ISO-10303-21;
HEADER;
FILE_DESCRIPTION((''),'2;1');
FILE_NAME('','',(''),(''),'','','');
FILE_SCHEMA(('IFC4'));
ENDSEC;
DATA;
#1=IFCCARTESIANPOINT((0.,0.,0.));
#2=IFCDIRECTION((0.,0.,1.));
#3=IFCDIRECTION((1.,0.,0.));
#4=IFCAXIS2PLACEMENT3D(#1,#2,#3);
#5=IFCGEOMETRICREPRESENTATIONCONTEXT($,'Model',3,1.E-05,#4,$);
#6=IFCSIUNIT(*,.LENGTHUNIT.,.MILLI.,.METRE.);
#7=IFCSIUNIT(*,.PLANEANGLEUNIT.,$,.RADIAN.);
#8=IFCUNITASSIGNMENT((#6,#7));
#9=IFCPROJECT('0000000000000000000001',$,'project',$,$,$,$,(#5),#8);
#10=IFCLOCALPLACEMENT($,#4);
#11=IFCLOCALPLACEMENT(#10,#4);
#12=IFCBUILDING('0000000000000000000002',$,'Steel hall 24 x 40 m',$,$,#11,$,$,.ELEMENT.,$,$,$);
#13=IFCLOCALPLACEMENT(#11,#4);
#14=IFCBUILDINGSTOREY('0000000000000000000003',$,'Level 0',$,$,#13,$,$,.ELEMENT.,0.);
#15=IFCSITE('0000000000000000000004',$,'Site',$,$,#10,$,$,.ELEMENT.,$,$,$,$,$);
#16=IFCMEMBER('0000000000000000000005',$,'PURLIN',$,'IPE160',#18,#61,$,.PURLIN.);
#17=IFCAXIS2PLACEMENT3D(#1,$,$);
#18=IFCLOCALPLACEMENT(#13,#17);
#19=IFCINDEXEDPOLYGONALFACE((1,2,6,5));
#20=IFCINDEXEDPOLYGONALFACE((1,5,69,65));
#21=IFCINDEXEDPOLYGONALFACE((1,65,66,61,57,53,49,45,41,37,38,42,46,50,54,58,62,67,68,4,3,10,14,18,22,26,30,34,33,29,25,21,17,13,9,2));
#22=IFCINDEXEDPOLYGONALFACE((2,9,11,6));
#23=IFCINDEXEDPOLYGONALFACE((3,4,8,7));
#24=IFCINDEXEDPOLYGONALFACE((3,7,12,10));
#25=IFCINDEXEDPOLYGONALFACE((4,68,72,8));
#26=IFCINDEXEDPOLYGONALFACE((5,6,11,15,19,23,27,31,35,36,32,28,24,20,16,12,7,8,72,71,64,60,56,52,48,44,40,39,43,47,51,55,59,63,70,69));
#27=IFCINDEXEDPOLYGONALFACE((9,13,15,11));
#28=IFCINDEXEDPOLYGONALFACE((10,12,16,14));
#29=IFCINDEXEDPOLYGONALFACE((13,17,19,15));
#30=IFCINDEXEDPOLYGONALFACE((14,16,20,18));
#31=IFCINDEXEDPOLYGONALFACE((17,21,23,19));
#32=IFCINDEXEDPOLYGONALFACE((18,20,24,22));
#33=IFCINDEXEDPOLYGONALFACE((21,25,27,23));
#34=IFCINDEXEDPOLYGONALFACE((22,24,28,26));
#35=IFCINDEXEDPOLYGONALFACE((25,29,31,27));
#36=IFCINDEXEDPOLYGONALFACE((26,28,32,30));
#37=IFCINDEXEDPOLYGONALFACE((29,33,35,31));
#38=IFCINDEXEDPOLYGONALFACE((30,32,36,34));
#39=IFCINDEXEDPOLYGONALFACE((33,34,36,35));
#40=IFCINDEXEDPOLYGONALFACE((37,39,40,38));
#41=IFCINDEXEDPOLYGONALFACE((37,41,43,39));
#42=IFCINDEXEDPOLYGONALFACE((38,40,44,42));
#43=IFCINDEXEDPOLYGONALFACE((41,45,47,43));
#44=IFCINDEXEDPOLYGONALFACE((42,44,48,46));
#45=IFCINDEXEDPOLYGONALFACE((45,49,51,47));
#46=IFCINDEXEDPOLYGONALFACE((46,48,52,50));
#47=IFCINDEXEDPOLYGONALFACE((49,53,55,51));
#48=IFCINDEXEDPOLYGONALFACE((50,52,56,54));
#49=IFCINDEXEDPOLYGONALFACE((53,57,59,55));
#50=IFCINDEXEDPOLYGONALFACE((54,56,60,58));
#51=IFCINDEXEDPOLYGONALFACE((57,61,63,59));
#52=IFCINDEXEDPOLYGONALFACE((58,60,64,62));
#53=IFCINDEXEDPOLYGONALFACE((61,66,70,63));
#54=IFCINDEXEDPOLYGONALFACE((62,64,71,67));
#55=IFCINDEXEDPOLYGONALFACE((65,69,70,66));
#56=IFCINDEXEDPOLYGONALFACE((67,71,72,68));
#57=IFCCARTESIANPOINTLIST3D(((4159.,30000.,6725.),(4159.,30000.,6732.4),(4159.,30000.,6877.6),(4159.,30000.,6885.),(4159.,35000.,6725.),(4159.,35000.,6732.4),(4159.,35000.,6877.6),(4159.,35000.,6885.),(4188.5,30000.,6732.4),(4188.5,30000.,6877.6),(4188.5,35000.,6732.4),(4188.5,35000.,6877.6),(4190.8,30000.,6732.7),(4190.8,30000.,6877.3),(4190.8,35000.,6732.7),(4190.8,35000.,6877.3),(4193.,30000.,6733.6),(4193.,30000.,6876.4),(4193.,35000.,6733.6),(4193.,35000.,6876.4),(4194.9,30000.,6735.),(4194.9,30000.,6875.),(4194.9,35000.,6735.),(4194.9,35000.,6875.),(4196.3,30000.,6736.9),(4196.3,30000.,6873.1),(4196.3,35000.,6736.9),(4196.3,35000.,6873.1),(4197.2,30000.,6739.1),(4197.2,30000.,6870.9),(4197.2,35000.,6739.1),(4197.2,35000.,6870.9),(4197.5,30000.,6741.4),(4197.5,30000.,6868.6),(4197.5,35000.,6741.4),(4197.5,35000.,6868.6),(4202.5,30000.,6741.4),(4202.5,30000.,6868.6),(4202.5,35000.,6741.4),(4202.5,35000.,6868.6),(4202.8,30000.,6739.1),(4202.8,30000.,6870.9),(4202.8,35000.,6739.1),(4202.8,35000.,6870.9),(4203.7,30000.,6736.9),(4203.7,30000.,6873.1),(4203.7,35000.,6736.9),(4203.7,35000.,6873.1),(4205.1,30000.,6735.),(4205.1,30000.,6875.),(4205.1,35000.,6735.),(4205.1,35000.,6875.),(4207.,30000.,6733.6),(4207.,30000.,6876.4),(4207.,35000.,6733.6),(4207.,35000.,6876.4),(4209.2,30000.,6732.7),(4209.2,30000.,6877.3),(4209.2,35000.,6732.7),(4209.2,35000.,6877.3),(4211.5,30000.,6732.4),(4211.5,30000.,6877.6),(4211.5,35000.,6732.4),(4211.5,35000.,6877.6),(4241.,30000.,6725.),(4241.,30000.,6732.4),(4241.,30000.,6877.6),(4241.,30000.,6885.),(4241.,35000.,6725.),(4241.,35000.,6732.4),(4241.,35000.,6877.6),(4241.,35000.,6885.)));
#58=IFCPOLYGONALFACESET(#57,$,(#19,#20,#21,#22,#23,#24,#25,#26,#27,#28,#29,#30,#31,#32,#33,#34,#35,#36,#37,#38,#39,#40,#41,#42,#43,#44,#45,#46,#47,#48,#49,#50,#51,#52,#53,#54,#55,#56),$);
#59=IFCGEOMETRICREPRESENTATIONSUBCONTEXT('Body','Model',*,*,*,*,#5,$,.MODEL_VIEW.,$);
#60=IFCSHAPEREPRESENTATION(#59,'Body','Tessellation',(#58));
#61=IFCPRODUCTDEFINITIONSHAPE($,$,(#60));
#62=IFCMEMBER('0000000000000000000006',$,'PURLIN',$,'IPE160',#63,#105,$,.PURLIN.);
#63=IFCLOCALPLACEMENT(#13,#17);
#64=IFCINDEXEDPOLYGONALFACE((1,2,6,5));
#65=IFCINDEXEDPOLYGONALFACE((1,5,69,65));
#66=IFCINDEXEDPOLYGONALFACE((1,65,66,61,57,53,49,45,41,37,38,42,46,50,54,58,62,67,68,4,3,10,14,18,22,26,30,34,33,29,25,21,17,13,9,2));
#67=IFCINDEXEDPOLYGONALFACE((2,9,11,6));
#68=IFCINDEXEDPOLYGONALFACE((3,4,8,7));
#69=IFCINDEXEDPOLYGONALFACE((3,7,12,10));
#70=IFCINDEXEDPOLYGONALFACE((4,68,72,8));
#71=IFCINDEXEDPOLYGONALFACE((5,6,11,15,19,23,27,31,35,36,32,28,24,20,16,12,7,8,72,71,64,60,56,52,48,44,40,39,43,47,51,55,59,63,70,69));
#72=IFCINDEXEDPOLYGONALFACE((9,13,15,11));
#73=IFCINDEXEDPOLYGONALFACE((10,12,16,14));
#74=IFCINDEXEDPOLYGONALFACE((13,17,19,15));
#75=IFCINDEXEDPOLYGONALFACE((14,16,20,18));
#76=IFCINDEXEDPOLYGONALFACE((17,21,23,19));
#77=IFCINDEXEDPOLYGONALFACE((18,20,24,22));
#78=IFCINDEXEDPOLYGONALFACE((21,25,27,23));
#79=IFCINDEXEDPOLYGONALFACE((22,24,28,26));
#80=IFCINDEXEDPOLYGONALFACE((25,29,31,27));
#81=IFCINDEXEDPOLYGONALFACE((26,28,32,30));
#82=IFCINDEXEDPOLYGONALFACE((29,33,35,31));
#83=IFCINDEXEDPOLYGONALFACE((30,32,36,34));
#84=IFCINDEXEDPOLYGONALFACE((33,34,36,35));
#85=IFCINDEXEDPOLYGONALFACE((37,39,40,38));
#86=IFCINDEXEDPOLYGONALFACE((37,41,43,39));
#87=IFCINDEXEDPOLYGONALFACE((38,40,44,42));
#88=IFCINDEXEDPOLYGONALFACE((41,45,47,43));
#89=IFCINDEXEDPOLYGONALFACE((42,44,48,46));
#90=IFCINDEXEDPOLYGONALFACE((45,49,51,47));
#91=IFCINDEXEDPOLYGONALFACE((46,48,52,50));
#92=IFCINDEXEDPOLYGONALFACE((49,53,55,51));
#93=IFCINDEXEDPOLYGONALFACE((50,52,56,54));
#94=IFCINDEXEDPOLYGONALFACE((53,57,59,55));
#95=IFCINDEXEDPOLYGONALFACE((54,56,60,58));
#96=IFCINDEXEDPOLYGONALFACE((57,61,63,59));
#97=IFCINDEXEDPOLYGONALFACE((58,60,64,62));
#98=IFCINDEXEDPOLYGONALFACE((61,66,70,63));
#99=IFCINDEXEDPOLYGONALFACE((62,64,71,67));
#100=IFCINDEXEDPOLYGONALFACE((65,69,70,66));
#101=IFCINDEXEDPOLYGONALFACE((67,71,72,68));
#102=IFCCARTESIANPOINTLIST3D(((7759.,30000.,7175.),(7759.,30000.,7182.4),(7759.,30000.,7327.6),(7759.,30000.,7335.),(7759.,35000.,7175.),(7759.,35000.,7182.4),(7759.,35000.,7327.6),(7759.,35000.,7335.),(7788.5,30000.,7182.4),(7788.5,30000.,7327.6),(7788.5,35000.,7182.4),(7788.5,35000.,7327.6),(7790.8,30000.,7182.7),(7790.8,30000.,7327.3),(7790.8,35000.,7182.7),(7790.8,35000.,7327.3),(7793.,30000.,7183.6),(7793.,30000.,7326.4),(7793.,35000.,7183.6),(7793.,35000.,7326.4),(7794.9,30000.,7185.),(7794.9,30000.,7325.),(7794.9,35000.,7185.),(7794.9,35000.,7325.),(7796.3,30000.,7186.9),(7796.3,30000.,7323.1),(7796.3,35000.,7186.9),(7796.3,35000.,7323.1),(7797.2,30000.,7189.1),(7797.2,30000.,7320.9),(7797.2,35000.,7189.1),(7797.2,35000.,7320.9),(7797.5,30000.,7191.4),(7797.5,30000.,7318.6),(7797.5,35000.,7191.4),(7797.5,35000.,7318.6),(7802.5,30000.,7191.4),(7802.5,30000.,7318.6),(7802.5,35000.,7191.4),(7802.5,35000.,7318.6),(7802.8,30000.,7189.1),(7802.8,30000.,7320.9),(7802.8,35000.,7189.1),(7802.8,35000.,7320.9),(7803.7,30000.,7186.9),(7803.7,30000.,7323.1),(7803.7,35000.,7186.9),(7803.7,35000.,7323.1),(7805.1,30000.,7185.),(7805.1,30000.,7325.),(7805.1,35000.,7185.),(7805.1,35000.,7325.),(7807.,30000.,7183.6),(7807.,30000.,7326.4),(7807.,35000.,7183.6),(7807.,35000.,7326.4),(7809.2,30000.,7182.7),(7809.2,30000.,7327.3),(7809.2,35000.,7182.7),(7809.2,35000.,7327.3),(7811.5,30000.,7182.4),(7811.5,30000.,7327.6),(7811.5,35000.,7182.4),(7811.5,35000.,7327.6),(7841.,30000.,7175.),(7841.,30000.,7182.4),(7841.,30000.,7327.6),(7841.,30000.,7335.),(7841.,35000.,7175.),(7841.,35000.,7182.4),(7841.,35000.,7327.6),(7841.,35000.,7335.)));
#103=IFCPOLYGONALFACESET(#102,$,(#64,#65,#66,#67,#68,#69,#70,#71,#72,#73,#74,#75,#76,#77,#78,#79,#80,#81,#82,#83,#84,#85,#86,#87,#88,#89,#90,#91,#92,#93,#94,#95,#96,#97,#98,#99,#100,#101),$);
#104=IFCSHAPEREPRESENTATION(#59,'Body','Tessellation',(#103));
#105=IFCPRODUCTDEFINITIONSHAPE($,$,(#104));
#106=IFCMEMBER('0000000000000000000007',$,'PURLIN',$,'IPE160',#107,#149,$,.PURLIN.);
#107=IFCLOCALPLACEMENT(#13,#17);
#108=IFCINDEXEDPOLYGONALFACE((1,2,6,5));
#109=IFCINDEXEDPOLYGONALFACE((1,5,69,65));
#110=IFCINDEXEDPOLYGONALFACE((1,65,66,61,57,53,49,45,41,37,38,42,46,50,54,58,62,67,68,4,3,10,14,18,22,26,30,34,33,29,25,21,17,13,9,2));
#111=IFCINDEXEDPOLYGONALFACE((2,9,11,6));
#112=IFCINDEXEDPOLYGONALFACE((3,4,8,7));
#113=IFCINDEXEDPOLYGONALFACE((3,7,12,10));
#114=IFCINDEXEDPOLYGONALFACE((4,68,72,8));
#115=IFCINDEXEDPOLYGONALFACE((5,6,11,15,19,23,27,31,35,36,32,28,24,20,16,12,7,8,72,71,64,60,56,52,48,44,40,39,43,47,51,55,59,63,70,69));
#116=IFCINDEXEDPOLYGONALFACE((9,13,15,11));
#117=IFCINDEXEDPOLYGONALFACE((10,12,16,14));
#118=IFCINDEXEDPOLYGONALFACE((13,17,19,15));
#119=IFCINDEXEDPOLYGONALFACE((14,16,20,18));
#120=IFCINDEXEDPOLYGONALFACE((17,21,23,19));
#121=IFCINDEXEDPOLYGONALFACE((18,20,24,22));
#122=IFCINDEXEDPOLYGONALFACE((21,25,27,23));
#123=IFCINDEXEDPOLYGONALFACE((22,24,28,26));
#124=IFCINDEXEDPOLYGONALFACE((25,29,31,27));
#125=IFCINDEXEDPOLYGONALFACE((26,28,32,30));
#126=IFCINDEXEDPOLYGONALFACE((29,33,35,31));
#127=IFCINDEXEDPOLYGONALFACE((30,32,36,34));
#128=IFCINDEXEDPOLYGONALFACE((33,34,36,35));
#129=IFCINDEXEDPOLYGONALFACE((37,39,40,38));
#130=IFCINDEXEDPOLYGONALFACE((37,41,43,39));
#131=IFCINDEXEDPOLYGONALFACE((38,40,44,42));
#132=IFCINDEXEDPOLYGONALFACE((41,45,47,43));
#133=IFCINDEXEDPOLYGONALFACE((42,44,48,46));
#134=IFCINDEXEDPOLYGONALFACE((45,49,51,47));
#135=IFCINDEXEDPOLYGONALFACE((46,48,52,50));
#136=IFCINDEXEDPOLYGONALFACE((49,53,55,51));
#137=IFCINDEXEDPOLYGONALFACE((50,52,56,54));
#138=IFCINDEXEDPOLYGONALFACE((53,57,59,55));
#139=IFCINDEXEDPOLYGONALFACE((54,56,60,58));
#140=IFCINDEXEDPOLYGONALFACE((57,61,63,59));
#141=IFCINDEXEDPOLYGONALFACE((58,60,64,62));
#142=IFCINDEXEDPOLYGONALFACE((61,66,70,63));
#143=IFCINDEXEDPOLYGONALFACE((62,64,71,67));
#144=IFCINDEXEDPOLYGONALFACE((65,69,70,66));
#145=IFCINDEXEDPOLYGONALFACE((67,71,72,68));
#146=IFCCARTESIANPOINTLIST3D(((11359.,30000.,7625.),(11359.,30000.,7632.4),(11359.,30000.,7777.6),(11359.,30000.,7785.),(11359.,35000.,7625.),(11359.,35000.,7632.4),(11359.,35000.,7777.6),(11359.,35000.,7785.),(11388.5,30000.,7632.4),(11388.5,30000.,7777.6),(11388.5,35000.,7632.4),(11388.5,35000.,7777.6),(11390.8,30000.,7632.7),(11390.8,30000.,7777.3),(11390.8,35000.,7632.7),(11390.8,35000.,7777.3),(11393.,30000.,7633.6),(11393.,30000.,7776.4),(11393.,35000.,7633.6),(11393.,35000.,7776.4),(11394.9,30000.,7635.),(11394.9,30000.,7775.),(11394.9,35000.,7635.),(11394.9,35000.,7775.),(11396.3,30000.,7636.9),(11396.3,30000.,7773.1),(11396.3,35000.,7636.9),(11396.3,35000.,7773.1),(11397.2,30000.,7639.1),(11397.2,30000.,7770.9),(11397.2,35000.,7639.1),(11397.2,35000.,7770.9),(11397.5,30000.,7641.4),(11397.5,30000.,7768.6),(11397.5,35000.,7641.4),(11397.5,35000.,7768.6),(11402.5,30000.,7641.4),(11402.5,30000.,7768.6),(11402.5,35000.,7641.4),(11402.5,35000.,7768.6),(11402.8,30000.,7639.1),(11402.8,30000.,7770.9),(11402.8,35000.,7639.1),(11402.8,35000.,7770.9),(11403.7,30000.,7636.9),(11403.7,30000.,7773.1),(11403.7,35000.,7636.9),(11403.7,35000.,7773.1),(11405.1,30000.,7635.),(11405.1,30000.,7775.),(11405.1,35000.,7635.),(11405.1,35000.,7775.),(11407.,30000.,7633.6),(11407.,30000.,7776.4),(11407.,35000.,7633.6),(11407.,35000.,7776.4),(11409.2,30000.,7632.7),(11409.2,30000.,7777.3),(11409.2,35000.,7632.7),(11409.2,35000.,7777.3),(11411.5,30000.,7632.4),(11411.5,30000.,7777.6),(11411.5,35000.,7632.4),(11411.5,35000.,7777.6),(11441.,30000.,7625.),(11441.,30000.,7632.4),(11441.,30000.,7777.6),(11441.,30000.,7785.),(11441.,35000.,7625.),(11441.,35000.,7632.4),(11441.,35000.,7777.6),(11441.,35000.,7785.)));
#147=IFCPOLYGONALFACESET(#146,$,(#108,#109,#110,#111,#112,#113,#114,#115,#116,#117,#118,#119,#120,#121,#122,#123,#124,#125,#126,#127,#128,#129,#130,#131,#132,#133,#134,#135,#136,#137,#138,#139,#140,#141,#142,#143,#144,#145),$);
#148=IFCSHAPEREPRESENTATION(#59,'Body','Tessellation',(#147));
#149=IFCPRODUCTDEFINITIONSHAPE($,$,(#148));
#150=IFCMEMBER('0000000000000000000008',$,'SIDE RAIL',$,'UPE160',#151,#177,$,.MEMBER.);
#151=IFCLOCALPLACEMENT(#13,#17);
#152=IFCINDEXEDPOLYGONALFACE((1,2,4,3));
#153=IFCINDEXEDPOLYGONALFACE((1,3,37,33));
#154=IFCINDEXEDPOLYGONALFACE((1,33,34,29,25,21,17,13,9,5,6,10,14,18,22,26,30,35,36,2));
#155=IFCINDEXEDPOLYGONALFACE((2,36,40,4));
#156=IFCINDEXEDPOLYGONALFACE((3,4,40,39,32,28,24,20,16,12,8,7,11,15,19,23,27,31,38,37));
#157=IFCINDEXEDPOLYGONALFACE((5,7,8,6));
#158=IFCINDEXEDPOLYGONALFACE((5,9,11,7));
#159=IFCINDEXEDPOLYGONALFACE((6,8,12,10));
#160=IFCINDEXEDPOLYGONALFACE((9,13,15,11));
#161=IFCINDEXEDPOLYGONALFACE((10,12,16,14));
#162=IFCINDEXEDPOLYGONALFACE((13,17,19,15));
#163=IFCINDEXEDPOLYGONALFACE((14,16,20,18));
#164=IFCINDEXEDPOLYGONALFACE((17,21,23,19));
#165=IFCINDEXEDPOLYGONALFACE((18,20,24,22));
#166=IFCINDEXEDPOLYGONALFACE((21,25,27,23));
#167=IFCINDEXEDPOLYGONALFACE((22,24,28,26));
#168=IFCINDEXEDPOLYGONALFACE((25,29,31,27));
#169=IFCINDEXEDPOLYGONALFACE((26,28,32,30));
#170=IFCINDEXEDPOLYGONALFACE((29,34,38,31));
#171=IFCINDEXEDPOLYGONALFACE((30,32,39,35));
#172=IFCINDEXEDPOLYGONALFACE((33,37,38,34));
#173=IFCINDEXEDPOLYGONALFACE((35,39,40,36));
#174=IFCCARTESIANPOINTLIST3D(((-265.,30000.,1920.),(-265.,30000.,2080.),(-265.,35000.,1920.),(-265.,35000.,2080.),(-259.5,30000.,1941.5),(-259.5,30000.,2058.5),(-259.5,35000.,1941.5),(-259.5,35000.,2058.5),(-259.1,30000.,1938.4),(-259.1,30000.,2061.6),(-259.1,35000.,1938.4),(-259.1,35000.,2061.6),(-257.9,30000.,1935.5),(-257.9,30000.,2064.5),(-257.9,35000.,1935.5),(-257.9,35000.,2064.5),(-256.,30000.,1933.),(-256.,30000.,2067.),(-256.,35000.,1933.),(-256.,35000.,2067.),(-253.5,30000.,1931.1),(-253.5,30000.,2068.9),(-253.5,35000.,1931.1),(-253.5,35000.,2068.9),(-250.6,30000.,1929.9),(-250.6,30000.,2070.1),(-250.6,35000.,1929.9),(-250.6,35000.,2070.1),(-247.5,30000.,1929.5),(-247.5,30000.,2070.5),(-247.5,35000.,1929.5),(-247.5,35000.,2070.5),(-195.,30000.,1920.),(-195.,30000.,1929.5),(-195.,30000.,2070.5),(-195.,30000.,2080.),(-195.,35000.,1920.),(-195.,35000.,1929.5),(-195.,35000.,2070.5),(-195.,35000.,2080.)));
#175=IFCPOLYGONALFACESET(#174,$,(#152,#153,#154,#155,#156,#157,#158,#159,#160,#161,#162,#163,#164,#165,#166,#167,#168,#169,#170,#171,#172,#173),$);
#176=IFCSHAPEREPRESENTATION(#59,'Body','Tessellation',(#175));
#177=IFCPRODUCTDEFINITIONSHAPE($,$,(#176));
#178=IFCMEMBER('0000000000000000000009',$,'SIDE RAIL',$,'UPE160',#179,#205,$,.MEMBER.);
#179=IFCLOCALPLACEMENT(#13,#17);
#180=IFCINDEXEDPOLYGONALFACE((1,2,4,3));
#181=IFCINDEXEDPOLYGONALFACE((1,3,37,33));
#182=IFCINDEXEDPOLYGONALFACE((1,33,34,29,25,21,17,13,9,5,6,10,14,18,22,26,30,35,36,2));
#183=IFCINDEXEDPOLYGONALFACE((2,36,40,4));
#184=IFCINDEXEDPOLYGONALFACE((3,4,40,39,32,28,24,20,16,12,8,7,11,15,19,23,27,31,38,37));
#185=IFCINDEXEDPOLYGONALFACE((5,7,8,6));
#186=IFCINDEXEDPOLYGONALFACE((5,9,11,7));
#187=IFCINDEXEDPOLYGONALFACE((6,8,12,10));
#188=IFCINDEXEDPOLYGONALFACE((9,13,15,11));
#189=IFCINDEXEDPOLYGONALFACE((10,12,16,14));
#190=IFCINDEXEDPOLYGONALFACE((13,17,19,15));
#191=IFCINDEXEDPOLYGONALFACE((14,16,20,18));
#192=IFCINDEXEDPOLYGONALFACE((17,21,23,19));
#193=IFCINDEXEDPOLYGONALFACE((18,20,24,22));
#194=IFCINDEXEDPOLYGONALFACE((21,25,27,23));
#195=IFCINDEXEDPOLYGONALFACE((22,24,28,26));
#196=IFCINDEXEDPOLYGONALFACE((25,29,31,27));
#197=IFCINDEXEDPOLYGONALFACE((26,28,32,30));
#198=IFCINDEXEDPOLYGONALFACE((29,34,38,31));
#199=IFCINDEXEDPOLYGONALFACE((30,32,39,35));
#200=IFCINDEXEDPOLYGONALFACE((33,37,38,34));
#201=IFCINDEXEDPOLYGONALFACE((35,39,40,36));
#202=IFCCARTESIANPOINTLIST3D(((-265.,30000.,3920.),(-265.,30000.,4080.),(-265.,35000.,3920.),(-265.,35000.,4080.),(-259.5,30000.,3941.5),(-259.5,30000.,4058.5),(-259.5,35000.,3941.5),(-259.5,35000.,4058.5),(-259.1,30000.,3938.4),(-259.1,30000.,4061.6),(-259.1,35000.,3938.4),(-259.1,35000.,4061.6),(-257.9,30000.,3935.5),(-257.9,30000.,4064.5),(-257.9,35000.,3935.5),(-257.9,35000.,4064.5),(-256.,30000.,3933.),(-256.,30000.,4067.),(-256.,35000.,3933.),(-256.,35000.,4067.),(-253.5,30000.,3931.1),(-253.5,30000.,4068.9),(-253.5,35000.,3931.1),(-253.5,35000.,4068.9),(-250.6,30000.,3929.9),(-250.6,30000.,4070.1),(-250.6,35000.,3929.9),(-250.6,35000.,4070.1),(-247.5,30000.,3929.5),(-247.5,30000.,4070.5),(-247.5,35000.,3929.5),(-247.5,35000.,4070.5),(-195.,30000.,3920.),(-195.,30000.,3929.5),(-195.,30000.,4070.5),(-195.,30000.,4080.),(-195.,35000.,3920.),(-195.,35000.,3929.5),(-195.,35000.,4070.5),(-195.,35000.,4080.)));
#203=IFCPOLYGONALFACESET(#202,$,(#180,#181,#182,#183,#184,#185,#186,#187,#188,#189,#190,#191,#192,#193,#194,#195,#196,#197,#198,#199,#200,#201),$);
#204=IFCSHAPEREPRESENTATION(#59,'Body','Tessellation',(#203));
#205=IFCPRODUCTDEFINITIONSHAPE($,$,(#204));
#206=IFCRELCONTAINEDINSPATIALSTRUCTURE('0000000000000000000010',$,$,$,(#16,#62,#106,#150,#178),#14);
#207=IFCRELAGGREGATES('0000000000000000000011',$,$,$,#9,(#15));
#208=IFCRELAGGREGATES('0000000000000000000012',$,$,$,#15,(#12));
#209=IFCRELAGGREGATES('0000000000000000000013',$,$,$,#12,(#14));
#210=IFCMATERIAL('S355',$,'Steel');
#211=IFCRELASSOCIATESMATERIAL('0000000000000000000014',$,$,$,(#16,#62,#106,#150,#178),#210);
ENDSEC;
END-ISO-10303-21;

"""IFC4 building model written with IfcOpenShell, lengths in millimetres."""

from ifc_helpers import new_model, si_unit, frame, origin_with_axes, place, context, subcontext, project, spatial, i_section, u_section, extrude, material, element, save


model = new_model("IFC4")

# Units and contexts
model_context = context("Model", 3, precision=1e-05, world=origin_with_axes())
body_context = subcontext(model_context, "Body", "Model", "MODEL_VIEW")
ifc_project = project(units=[si_unit("LENGTHUNIT", "METRE", prefix="MILLI"), si_unit("PLANEANGLEUNIT", "RADIAN")], contexts=[model_context])

# Site, building, storey
site_placement = place(None, origin_with_axes())
site = spatial("IfcSite", under=ifc_project, at=site_placement, Name="Site", CompositionType="ELEMENT")
building_placement = place(site_placement, origin_with_axes())
building = spatial("IfcBuilding", under=site, at=building_placement, Name="Steel hall 24 x 40 m", CompositionType="ELEMENT")
storey_placement = place(building_placement, origin_with_axes())
storey = spatial("IfcBuildingStorey", under=building, at=storey_placement, Name="Level 0", CompositionType="ELEMENT", Elevation=0.0)

# Shared definitions
ifc_material = material(Name="S355", Category="Steel")

# Members
for number, where, z_axis, x_axis, name in (
    (1, (4200.0, 30000.0, 6805.0), (0.0, 1.0, 0.0), (1.0, 0.0, 0.0), "PURLIN"),
    (2, (7800.0, 30000.0, 7255.0), (0.0, 1.0, 0.0), (1.0, 0.0, 0.0), "PURLIN"),
    (3, (11400.0, 30000.0, 7705.0), (0.0, 1.0, 0.0), (1.0, 0.0, 0.0), "PURLIN"),
):
    element("IfcMember", number, at=place(storey_placement, frame(where, z_axis=z_axis, x_axis=x_axis)), inside=storey, material=ifc_material, Name=name, ObjectType="IPE160", PredefinedType="PURLIN", context=body_context, shape_type="SweptSolid", body=[
        extrude(i_section(OverallWidth=82.0, OverallDepth=160.0, WebThickness=5.0, FlangeThickness=7.4, FilletRadius=9.0), origin_with_axes(), (0.0, 0.0, 1.0), 5000.0),
    ])
for number, where, z_axis, x_axis, name in (
    (4, (-230.0, 30000.0, 2000.0), (0.0, 1.0, 0.0), (1.0, 0.0, 0.0), "SIDE RAIL"),
    (5, (-230.0, 30000.0, 4000.0), (0.0, 1.0, 0.0), (1.0, 0.0, 0.0), "SIDE RAIL"),
):
    element("IfcMember", number, at=place(storey_placement, frame(where, z_axis=z_axis, x_axis=x_axis)), inside=storey, material=ifc_material, Name=name, ObjectType="UPE160", PredefinedType="MEMBER", context=body_context, shape_type="SweptSolid", body=[
        extrude(u_section(Depth=160.0, FlangeWidth=70.0, WebThickness=5.5, FlangeThickness=9.5, FilletRadius=12.0), origin_with_axes(), (0.0, 0.0, 1.0), 5000.0),
    ])

save(model, "model.ifc")
